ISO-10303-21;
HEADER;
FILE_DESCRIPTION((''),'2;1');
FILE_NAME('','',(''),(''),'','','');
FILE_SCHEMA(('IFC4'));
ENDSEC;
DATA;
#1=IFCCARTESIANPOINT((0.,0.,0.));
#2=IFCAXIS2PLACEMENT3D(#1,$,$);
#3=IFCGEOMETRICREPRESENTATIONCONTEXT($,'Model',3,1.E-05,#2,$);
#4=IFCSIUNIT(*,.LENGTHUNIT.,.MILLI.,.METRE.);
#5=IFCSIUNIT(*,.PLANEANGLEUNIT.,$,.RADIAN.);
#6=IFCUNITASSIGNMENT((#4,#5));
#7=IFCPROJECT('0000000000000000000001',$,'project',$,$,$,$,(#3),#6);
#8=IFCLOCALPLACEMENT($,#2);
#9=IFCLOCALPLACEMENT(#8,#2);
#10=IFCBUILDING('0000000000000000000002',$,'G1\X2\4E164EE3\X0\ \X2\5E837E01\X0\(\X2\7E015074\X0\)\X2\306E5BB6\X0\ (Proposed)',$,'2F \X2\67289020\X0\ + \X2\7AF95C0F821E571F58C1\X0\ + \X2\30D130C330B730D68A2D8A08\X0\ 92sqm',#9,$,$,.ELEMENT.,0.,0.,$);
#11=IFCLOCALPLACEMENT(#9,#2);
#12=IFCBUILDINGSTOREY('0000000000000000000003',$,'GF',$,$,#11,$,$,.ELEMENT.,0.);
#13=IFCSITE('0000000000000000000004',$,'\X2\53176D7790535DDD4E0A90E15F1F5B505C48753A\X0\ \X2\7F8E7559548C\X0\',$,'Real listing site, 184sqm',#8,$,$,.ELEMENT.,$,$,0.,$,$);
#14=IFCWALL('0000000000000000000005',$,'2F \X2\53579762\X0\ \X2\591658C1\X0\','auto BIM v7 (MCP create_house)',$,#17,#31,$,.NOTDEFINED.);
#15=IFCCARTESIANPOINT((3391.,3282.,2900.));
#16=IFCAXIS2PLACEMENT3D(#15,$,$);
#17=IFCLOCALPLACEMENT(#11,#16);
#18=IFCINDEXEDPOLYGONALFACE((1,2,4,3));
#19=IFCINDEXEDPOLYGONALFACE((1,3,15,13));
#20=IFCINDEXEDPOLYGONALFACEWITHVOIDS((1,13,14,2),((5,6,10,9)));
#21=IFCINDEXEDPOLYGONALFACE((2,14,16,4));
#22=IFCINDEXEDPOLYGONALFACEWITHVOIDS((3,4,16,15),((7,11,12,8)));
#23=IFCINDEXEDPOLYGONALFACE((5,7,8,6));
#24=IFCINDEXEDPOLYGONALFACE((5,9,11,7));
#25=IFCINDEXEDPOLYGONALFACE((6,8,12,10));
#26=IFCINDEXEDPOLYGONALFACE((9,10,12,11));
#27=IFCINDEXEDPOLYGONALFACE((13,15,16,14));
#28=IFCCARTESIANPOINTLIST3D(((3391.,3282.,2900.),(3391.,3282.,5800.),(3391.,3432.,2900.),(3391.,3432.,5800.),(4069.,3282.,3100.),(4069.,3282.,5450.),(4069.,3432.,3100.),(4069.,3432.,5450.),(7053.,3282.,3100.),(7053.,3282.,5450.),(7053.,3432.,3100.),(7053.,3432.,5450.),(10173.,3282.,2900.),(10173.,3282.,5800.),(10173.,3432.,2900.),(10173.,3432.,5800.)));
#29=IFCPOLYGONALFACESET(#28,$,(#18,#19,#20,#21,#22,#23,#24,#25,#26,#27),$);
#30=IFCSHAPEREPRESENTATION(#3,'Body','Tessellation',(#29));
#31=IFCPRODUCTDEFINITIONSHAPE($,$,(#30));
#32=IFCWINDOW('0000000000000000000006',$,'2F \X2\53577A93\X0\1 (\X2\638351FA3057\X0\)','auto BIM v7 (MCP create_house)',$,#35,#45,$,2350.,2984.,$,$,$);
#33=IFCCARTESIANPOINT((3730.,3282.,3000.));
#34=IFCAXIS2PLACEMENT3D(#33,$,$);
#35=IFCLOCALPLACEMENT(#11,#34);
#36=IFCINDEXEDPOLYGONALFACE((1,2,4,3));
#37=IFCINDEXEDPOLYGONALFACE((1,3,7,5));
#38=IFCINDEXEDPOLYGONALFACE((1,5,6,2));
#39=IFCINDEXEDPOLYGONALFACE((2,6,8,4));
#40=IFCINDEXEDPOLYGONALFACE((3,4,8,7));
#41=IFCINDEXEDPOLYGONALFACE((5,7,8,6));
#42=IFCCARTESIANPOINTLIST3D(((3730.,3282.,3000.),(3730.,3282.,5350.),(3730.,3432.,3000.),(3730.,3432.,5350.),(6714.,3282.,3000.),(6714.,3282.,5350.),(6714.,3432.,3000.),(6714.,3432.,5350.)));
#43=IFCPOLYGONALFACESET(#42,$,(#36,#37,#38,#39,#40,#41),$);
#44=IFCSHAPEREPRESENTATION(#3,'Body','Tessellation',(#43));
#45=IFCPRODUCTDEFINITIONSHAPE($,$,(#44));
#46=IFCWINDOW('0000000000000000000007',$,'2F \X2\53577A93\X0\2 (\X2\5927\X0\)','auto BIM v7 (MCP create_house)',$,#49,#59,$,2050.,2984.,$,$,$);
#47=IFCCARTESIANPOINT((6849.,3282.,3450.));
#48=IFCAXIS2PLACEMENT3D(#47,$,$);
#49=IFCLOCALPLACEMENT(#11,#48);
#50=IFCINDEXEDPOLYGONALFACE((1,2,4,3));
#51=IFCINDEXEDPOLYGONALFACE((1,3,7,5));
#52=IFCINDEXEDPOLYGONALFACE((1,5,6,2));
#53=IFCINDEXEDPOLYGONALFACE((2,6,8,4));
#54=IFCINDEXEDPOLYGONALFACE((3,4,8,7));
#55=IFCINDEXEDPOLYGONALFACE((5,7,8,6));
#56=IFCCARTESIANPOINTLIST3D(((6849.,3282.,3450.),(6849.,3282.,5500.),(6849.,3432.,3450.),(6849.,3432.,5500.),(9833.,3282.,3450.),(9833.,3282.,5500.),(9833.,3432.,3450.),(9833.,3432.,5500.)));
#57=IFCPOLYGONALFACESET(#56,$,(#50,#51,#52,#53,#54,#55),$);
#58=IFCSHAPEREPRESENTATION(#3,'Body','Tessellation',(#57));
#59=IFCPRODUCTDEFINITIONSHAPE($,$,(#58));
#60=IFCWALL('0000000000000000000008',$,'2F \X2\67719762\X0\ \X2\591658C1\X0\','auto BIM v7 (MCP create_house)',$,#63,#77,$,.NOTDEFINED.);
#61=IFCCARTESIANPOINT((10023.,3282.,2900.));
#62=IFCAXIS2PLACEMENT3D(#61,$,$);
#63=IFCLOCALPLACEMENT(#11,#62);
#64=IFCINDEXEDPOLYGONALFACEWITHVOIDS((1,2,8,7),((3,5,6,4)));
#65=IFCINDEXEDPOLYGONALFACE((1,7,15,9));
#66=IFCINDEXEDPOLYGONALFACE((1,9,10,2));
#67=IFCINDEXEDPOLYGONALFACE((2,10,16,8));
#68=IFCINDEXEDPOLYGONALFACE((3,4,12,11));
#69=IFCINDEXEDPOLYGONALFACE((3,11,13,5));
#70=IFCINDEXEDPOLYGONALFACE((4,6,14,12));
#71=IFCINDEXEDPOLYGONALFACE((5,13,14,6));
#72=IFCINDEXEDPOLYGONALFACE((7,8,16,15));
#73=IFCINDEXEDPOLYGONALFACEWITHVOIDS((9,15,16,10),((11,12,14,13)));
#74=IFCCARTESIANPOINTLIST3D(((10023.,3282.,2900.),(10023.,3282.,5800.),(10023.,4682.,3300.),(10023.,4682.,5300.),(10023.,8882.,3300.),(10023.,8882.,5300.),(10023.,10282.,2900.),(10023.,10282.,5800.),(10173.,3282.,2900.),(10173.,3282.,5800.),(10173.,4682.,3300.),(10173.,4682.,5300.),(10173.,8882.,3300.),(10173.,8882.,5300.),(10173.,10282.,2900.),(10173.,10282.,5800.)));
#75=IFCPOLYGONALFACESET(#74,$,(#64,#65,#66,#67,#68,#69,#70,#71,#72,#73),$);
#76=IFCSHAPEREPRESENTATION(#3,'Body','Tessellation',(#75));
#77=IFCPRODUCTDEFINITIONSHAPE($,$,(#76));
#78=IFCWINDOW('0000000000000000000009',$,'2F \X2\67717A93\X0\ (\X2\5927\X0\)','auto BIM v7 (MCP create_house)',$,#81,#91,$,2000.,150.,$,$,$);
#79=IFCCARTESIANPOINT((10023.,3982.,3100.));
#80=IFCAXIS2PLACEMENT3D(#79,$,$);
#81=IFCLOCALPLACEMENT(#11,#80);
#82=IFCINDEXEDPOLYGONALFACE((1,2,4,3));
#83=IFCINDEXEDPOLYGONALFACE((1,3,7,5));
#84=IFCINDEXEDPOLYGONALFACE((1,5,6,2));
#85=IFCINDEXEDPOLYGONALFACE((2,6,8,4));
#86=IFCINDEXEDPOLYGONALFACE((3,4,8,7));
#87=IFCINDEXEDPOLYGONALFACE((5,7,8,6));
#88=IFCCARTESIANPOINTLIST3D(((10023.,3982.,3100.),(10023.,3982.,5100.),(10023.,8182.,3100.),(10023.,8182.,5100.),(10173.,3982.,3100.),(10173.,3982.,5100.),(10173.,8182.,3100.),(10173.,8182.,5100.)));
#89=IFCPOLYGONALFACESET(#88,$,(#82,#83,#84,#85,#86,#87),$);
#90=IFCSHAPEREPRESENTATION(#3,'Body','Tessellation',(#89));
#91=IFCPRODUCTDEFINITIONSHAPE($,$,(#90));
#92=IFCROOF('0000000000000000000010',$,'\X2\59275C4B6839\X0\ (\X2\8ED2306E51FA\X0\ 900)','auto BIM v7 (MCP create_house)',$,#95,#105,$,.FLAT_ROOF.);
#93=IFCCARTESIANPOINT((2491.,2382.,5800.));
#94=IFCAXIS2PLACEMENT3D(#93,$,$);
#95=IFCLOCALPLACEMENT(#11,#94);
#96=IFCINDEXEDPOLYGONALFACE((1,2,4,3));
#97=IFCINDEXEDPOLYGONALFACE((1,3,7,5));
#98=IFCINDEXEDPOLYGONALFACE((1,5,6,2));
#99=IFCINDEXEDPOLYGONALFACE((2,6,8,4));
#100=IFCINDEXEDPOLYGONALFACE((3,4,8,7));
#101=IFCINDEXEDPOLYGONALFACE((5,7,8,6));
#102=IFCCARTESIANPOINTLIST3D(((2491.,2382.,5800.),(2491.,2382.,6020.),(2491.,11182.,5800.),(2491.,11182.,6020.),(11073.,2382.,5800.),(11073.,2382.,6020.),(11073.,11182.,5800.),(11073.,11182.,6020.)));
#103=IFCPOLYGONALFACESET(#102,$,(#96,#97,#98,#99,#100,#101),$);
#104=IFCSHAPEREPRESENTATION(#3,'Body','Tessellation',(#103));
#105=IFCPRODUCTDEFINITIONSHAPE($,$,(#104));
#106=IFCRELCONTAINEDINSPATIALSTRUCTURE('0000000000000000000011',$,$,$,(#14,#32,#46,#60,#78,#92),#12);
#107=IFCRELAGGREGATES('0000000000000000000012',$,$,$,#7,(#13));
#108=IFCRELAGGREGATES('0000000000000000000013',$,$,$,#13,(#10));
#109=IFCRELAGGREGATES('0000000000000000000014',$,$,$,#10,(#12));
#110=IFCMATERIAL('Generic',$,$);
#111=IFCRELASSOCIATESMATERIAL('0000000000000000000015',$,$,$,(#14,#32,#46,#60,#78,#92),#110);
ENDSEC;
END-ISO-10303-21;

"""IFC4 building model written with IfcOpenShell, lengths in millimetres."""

from ifc_helpers import new_model, si_unit, frame, frame_2d, origin, place, context, project, spatial, rectangle, extrude, material, element, fill, save


model = new_model("IFC4")

# Units and contexts
model_context = context("Model", 3, precision=1e-05, world=origin())
ifc_project = project(units=[si_unit("LENGTHUNIT", "METRE", prefix="MILLI"), si_unit("PLANEANGLEUNIT", "RADIAN")], contexts=[model_context])

# Site, building, storey
site_placement = place(None, origin())
site = spatial("IfcSite", under=ifc_project, at=site_placement, Name="北海道川上郡弟子屈町 美留和", ObjectType="Real listing site, 184sqm", CompositionType="ELEMENT", RefElevation=0.0)
building_placement = place(site_placement, origin())
building = spatial("IfcBuilding", under=site, at=building_placement, Name="G1世代 広縁(縁側)の家 (Proposed)", ObjectType="2F 木造 + 竹小舞土壁 + パッシブ設計 92sqm", CompositionType="ELEMENT", ElevationOfRefHeight=0.0, ElevationOfTerrain=0.0)
storey_placement = place(building_placement, origin())
storey = spatial("IfcBuildingStorey", under=building, at=storey_placement, Name="GF", CompositionType="ELEMENT", Elevation=0.0)

# Shared definitions
ifc_material = material(Name="Generic")

# Wall, openings, windows
wall_1_placement = place(storey_placement, frame((3391.0, 3282.0, 2900.0)))
wall_1 = element("IfcWall", 1, at=wall_1_placement, inside=storey, material=ifc_material, Name="2F 南面 外壁", Description="auto BIM v7 (MCP create_house)", PredefinedType="NOTDEFINED", context=model_context, shape_type="SweptSolid", body=[
    extrude(rectangle(XDim=6782.0, YDim=150.0, at=frame_2d((3391.0, 75.0))), frame((3391.0, 3282.0, 2900.0)), (0.0, 0.0, 1.0), 2900.0),
])
opening_1_placement = place(storey_placement, frame((3730.0, 3282.0, 3000.0)))
opening_1 = element("IfcOpeningElement", 2, at=opening_1_placement, cuts=wall_1, PredefinedType="NOTDEFINED", context=model_context, shape_type="SweptSolid", body=[
    extrude(rectangle(XDim=2984.0, YDim=150.0, at=frame_2d((1492.0, 75.0))), frame((3730.0, 3282.0, 3000.0)), (0.0, 0.0, 1.0), 2350.0),
])
opening_2_placement = place(storey_placement, frame((6849.0, 3282.0, 3450.0)))
opening_2 = element("IfcOpeningElement", 3, at=opening_2_placement, cuts=wall_1, PredefinedType="NOTDEFINED", context=model_context, shape_type="SweptSolid", body=[
    extrude(rectangle(XDim=2984.0, YDim=150.0, at=frame_2d((1492.0, 75.0))), frame((6849.0, 3282.0, 3450.0)), (0.0, 0.0, 1.0), 2050.0),
])
window_1_placement = place(storey_placement, frame((3730.0, 3282.0, 3000.0)))
window_1 = element("IfcWindow", 4, at=window_1_placement, inside=storey, material=ifc_material, Name="2F 南窓1 (掃出し)", Description="auto BIM v7 (MCP create_house)", OverallHeight=2350.0, OverallWidth=2984.0, context=model_context, shape_type="SweptSolid", body=[
    extrude(rectangle(XDim=2984.0, YDim=150.0, at=frame_2d((1492.0, 75.0))), frame((3730.0, 3282.0, 3000.0)), (0.0, 0.0, 1.0), 2350.0),
])
fill(opening_1, window_1)
window_2_placement = place(storey_placement, frame((6849.0, 3282.0, 3450.0)))
window_2 = element("IfcWindow", 5, at=window_2_placement, inside=storey, material=ifc_material, Name="2F 南窓2 (大)", Description="auto BIM v7 (MCP create_house)", OverallHeight=2050.0, OverallWidth=2984.0, context=model_context, shape_type="SweptSolid", body=[
    extrude(rectangle(XDim=2984.0, YDim=150.0, at=frame_2d((1492.0, 75.0))), frame((6849.0, 3282.0, 3450.0)), (0.0, 0.0, 1.0), 2050.0),
])
fill(opening_2, window_2)

# Wall, opening, window
wall_2_placement = place(storey_placement, frame((10023.0, 3282.0, 2900.0)))
wall_2 = element("IfcWall", 6, at=wall_2_placement, inside=storey, material=ifc_material, Name="2F 東面 外壁", Description="auto BIM v7 (MCP create_house)", PredefinedType="NOTDEFINED", context=model_context, shape_type="SweptSolid", body=[
    extrude(rectangle(XDim=150.0, YDim=7000.0, at=frame_2d((75.0, 3500.0))), frame((10023.0, 3282.0, 2900.0)), (0.0, 0.0, 1.0), 2900.0),
])
opening_3_placement = place(storey_placement, frame((10023.0, 3982.0, 3100.0)))
opening_3 = element("IfcOpeningElement", 7, at=opening_3_placement, cuts=wall_2, PredefinedType="NOTDEFINED", context=model_context, shape_type="SweptSolid", body=[
    extrude(rectangle(XDim=150.0, YDim=4200.0, at=frame_2d((75.0, 2100.0))), frame((10023.0, 3982.0, 3100.0)), (0.0, 0.0, 1.0), 2000.0),
])
window_3_placement = place(storey_placement, frame((10023.0, 3982.0, 3100.0)))
window_3 = element("IfcWindow", 8, at=window_3_placement, inside=storey, material=ifc_material, Name="2F 東窓 (大)", Description="auto BIM v7 (MCP create_house)", OverallHeight=2000.0, OverallWidth=150.0, context=model_context, shape_type="SweptSolid", body=[
    extrude(rectangle(XDim=150.0, YDim=4200.0, at=frame_2d((75.0, 2100.0))), frame((10023.0, 3982.0, 3100.0)), (0.0, 0.0, 1.0), 2000.0),
])
fill(opening_3, window_3)

# Roof
roof_placement = place(storey_placement, frame((2491.0, 2382.0, 5800.0)))
element("IfcRoof", 9, at=roof_placement, inside=storey, material=ifc_material, Name="大屋根 (軒の出 900)", Description="auto BIM v7 (MCP create_house)", PredefinedType="FLAT_ROOF", context=model_context, shape_type="SweptSolid", body=[
    extrude(rectangle(XDim=8582.0, YDim=8800.0, at=frame_2d((4291.0, 4400.0))), frame((2491.0, 2382.0, 5800.0)), (0.0, 0.0, 1.0), 220.0),
])

save(model, "model.ifc")
